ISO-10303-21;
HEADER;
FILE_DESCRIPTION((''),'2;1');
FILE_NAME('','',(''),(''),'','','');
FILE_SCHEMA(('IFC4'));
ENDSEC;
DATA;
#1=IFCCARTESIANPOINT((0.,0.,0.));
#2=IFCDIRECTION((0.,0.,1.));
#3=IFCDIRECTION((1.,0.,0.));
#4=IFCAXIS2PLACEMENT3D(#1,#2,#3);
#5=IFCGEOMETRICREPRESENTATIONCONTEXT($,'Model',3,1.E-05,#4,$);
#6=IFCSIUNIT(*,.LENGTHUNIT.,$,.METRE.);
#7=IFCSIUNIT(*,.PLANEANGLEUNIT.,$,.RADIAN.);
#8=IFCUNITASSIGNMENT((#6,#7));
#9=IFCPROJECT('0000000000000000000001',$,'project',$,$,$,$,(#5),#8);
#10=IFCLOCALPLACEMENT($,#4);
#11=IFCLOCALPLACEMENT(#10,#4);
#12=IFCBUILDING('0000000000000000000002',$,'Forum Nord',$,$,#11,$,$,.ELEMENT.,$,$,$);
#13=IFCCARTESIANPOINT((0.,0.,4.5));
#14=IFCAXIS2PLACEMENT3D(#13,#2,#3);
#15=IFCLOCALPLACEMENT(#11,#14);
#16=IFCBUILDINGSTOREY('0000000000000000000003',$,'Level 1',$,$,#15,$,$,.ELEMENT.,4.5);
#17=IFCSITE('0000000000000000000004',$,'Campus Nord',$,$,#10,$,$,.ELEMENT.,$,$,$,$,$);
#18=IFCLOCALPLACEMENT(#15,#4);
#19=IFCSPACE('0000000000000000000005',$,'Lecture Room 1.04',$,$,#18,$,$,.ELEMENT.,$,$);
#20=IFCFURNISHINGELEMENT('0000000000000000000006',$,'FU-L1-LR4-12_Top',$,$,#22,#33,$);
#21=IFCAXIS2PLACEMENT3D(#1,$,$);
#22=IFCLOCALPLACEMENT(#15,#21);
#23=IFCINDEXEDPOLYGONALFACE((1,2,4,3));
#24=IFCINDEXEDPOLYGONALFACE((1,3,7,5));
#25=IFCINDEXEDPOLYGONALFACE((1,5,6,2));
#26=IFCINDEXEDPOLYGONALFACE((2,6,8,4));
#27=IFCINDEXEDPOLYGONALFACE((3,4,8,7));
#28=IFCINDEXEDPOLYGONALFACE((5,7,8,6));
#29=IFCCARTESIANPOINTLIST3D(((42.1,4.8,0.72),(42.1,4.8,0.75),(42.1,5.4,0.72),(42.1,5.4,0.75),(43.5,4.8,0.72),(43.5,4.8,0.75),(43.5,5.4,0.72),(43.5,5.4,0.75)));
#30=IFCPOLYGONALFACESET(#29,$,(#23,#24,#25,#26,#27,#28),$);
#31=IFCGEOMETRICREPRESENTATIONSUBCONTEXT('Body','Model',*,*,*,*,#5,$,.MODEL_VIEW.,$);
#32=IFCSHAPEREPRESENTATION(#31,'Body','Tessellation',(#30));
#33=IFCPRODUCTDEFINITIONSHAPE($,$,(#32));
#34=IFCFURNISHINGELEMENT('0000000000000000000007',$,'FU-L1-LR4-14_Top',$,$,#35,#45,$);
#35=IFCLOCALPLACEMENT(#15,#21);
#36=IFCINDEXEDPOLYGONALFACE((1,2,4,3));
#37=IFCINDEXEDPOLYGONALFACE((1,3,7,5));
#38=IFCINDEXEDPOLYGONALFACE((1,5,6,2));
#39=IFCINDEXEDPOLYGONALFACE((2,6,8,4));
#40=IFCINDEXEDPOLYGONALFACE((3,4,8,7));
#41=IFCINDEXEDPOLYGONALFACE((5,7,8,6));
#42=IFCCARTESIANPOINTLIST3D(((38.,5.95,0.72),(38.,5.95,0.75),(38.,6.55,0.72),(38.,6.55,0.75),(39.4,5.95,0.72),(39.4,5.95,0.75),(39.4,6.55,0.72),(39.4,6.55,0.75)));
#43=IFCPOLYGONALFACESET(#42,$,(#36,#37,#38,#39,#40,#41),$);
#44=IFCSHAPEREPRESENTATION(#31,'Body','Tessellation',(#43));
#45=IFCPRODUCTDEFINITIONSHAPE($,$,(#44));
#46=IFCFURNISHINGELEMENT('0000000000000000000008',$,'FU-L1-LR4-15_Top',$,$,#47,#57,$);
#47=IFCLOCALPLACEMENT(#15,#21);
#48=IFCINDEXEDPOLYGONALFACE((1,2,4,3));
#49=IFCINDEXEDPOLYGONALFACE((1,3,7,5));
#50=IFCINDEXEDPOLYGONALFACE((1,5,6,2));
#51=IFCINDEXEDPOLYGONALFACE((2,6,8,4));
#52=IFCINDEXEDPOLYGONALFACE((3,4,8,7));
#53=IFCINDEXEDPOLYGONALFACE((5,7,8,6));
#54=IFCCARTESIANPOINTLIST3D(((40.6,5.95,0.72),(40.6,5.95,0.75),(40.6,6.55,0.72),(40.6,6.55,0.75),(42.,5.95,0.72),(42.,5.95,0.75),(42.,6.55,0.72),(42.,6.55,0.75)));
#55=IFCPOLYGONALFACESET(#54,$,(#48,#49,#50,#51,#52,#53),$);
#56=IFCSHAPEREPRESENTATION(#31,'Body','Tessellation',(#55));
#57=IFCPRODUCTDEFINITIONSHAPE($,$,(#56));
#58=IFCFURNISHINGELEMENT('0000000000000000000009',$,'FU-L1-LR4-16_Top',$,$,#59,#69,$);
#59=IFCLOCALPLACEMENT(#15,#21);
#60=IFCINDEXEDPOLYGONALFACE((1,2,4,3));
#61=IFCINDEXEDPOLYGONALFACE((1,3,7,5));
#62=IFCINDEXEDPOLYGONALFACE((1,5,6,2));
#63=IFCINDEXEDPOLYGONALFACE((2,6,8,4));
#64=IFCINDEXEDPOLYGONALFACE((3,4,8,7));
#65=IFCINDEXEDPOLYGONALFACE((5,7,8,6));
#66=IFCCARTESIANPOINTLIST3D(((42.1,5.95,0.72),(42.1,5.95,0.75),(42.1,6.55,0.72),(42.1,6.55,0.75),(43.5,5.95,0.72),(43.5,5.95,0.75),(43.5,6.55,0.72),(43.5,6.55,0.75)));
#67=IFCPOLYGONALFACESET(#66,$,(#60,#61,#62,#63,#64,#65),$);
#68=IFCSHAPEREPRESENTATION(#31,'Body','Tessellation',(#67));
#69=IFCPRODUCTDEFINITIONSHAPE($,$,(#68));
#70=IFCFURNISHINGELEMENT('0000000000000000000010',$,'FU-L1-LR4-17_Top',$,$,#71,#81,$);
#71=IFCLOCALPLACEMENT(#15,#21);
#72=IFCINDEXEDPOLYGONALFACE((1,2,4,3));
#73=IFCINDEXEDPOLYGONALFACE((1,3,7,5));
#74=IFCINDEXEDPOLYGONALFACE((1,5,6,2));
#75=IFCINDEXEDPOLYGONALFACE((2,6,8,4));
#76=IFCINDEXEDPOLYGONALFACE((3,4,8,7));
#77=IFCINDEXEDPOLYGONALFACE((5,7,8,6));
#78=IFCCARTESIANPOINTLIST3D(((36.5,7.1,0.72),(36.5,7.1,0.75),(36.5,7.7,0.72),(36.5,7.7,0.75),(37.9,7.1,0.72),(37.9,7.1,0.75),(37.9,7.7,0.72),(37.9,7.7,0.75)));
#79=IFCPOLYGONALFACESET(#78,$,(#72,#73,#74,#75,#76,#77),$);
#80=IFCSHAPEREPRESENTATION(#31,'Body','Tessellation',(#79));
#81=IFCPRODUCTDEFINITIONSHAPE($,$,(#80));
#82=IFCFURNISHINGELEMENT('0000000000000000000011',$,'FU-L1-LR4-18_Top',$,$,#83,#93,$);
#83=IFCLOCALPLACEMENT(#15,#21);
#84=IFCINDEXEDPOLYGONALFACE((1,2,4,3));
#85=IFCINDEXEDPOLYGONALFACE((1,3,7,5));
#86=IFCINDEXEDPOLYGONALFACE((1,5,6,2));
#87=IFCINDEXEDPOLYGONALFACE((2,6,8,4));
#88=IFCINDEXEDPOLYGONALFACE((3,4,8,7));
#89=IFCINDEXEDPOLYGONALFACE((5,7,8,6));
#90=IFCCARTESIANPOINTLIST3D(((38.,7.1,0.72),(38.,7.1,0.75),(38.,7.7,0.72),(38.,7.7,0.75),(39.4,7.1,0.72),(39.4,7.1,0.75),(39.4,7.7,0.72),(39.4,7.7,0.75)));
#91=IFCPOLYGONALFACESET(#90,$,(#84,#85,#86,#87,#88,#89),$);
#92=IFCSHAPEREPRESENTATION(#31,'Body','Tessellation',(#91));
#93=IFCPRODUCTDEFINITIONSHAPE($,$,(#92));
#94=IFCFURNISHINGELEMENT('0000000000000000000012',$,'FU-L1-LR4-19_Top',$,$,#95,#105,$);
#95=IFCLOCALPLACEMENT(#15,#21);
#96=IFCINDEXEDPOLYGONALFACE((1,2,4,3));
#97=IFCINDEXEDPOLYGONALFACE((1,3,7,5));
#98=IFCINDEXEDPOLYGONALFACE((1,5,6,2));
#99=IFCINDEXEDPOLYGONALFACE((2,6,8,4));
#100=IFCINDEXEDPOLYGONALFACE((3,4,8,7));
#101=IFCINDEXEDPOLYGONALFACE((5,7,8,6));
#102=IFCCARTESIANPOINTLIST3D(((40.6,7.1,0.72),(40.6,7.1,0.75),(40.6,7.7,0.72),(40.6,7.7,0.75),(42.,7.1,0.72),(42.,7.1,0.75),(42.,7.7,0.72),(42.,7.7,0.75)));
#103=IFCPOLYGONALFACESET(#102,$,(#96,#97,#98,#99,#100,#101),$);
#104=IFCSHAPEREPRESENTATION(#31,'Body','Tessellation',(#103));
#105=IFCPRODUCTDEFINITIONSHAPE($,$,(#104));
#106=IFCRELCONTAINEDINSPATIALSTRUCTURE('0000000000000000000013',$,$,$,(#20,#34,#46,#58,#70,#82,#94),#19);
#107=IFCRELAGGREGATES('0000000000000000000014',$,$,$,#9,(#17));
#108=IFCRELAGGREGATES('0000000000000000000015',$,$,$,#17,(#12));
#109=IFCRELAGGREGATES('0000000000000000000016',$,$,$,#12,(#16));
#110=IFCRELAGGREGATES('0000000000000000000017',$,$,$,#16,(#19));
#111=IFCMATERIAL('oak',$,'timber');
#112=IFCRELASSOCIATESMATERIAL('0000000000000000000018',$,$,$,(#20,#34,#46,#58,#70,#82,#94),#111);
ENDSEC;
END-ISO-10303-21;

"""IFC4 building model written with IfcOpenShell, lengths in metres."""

from ifc_helpers import new_model, si_unit, frame, frame_2d, origin_with_axes, place, context, subcontext, project, spatial, rectangle, extrude, material, element, save


model = new_model("IFC4")

# Units and contexts
model_context = context("Model", 3, precision=1e-05, world=origin_with_axes())
body_context = subcontext(model_context, "Body", "Model", "MODEL_VIEW")
ifc_project = project(units=[si_unit("LENGTHUNIT", "METRE"), si_unit("PLANEANGLEUNIT", "RADIAN")], contexts=[model_context])

# Site, building, storey, space
site_placement = place(None, origin_with_axes())
site = spatial("IfcSite", under=ifc_project, at=site_placement, Name="Campus Nord", CompositionType="ELEMENT")
building_placement = place(site_placement, origin_with_axes())
building = spatial("IfcBuilding", under=site, at=building_placement, Name="Forum Nord", CompositionType="ELEMENT")
storey_placement = place(building_placement, frame((0.0, 0.0, 4.5), z_axis=(0.0, 0.0, 1.0), x_axis=(1.0, 0.0, 0.0)))
storey = spatial("IfcBuildingStorey", under=building, at=storey_placement, Name="Level 1", CompositionType="ELEMENT", Elevation=4.5)
space_placement = place(storey_placement, origin_with_axes())
space = spatial("IfcSpace", under=storey, at=space_placement, Name="Lecture Room 1.04", CompositionType="ELEMENT")

# Furnishing elements
ifc_material_1 = material(Name="oak", Category="timber")
furnishing_1_placement = place(storey_placement, frame((42.1, 4.8, 0.0), z_axis=(0.0, 0.0, 1.0), x_axis=(1.0, 0.0, 0.0)))
element("IfcFurnishingElement", 1, at=furnishing_1_placement, inside=space, material=ifc_material_1, Name="FU-L1-LR4-12_Top", context=body_context, shape_type="SweptSolid", body=[
    extrude(rectangle(XDim=1.4, YDim=0.6, at=frame_2d((0.7, 0.3), x_axis=(1.0, 0.0))), frame((0.0, 0.0, 0.72), z_axis=(0.0, 0.0, 1.0), x_axis=(1.0, 0.0, 0.0)), (0.0, 0.0, 1.0), 0.03),
])
furnishing_2_placement = place(storey_placement, frame((38.0, 5.95, 0.0), z_axis=(0.0, 0.0, 1.0), x_axis=(1.0, 0.0, 0.0)))
element("IfcFurnishingElement", 2, at=furnishing_2_placement, inside=space, material=ifc_material_1, Name="FU-L1-LR4-14_Top", context=body_context, shape_type="SweptSolid", body=[
    extrude(rectangle(XDim=1.4, YDim=0.6, at=frame_2d((0.7, 0.3), x_axis=(1.0, 0.0))), frame((0.0, 0.0, 0.72), z_axis=(0.0, 0.0, 1.0), x_axis=(1.0, 0.0, 0.0)), (0.0, 0.0, 1.0), 0.03),
])
furnishing_3_placement = place(storey_placement, frame((40.6, 5.95, 0.0), z_axis=(0.0, 0.0, 1.0), x_axis=(1.0, 0.0, 0.0)))
element("IfcFurnishingElement", 3, at=furnishing_3_placement, inside=space, material=ifc_material_1, Name="FU-L1-LR4-15_Top", context=body_context, shape_type="SweptSolid", body=[
    extrude(rectangle(XDim=1.4, YDim=0.6, at=frame_2d((0.7, 0.3), x_axis=(1.0, 0.0))), frame((0.0, 0.0, 0.72), z_axis=(0.0, 0.0, 1.0), x_axis=(1.0, 0.0, 0.0)), (0.0, 0.0, 1.0), 0.03),
])
furnishing_4_placement = place(storey_placement, frame((42.1, 5.95, 0.0), z_axis=(0.0, 0.0, 1.0), x_axis=(1.0, 0.0, 0.0)))
element("IfcFurnishingElement", 4, at=furnishing_4_placement, inside=space, material=ifc_material_1, Name="FU-L1-LR4-16_Top", context=body_context, shape_type="SweptSolid", body=[
    extrude(rectangle(XDim=1.4, YDim=0.6, at=frame_2d((0.7, 0.3), x_axis=(1.0, 0.0))), frame((0.0, 0.0, 0.72), z_axis=(0.0, 0.0, 1.0), x_axis=(1.0, 0.0, 0.0)), (0.0, 0.0, 1.0), 0.03),
])
furnishing_5_placement = place(storey_placement, frame((36.5, 7.1, 0.0), z_axis=(0.0, 0.0, 1.0), x_axis=(1.0, 0.0, 0.0)))
element("IfcFurnishingElement", 5, at=furnishing_5_placement, inside=space, material=ifc_material_1, Name="FU-L1-LR4-17_Top", context=body_context, shape_type="SweptSolid", body=[
    extrude(rectangle(XDim=1.4, YDim=0.6, at=frame_2d((0.7, 0.3), x_axis=(1.0, 0.0))), frame((0.0, 0.0, 0.72), z_axis=(0.0, 0.0, 1.0), x_axis=(1.0, 0.0, 0.0)), (0.0, 0.0, 1.0), 0.03),
])
furnishing_6_placement = place(storey_placement, frame((38.0, 7.1, 0.0), z_axis=(0.0, 0.0, 1.0), x_axis=(1.0, 0.0, 0.0)))
element("IfcFurnishingElement", 6, at=furnishing_6_placement, inside=space, material=ifc_material_1, Name="FU-L1-LR4-18_Top", context=body_context, shape_type="SweptSolid", body=[
    extrude(rectangle(XDim=1.4, YDim=0.6, at=frame_2d((0.7, 0.3), x_axis=(1.0, 0.0))), frame((0.0, 0.0, 0.72), z_axis=(0.0, 0.0, 1.0), x_axis=(1.0, 0.0, 0.0)), (0.0, 0.0, 1.0), 0.03),
])
furnishing_7_placement = place(storey_placement, frame((40.6, 7.1, 0.0), z_axis=(0.0, 0.0, 1.0), x_axis=(1.0, 0.0, 0.0)))
element("IfcFurnishingElement", 7, at=furnishing_7_placement, inside=space, material=ifc_material_1, Name="FU-L1-LR4-19_Top", context=body_context, shape_type="SweptSolid", body=[
    extrude(rectangle(XDim=1.4, YDim=0.6, at=frame_2d((0.7, 0.3), x_axis=(1.0, 0.0))), frame((0.0, 0.0, 0.72), z_axis=(0.0, 0.0, 1.0), x_axis=(1.0, 0.0, 0.0)), (0.0, 0.0, 1.0), 0.03),
])

save(model, "model.ifc")
